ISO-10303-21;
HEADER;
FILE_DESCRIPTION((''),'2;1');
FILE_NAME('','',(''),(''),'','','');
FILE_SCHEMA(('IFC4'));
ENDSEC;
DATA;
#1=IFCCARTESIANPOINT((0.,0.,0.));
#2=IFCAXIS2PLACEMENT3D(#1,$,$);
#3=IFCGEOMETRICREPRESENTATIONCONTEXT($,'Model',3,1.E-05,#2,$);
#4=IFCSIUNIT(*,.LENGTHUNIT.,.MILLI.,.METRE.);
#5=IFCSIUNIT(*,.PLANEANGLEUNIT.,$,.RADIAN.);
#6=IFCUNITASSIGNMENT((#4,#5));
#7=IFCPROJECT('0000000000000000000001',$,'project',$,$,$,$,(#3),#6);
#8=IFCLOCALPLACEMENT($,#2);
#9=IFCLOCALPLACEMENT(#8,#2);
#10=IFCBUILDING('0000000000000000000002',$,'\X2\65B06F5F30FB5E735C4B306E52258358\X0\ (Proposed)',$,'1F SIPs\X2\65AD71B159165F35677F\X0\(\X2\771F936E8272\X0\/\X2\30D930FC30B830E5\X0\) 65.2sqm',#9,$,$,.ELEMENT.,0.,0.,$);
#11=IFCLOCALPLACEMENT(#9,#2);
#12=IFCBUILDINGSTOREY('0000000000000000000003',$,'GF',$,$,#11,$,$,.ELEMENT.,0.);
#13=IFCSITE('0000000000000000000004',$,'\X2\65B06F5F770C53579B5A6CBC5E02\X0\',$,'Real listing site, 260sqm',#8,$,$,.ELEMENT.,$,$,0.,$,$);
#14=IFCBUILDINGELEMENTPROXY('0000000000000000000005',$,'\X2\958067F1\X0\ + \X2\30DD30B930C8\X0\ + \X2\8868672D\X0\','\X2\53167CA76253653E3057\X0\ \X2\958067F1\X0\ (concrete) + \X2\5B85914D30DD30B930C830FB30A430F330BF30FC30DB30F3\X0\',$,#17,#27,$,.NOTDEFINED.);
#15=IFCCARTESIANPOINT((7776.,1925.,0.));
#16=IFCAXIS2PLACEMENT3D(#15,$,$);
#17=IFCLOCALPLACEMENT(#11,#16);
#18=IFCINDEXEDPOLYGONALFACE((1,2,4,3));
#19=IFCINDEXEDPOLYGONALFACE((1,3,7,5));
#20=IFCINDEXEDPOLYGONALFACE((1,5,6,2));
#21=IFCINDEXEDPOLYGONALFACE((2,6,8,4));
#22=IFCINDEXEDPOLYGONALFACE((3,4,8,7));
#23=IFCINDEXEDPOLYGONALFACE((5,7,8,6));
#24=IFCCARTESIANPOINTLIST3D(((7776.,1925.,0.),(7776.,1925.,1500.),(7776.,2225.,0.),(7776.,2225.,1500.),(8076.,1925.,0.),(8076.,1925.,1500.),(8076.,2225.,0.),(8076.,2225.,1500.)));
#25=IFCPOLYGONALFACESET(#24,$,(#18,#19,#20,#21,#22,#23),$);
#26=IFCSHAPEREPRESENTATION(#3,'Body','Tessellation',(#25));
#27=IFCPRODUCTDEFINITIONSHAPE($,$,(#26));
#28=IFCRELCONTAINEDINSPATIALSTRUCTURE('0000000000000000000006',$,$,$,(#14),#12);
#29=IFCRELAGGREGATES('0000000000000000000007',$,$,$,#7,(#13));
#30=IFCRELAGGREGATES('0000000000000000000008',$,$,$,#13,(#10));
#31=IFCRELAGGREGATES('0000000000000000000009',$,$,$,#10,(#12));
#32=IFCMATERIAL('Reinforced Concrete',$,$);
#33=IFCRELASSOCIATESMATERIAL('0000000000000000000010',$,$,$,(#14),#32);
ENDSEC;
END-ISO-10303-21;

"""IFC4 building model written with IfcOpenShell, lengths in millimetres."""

from ifc_helpers import new_model, si_unit, frame, frame_2d, origin, place, context, project, spatial, rectangle, extrude, material, element, save


model = new_model("IFC4")

# Units and contexts
model_context = context("Model", 3, precision=1e-05, world=origin())
ifc_project = project(units=[si_unit("LENGTHUNIT", "METRE", prefix="MILLI"), si_unit("PLANEANGLEUNIT", "RADIAN")], contexts=[model_context])

# Site, building, storey
site_placement = place(None, origin())
site = spatial("IfcSite", under=ifc_project, at=site_placement, Name="新潟県南魚沼市", ObjectType="Real listing site, 260sqm", CompositionType="ELEMENT", RefElevation=0.0)
building_placement = place(site_placement, origin())
building = spatial("IfcBuilding", under=site, at=building_placement, Name="新潟・平屋の別荘 (Proposed)", ObjectType="1F SIPs断熱外張板(真鍮色/ベージュ) 65.2sqm", CompositionType="ELEMENT", ElevationOfRefHeight=0.0, ElevationOfTerrain=0.0)
storey_placement = place(building_placement, origin())
storey = spatial("IfcBuildingStorey", under=building, at=storey_placement, Name="GF", CompositionType="ELEMENT", Elevation=0.0)

# Shared definitions
ifc_material_1 = material(Name="Reinforced Concrete")

# Building element proxy
proxy_placement = place(storey_placement, frame((7776.0, 1925.0, 0.0)))
element("IfcBuildingElementProxy", 1, at=proxy_placement, inside=storey, material=ifc_material_1, Name="門柱 + ポスト + 表札", Description="化粧打放し 門柱 (concrete) + 宅配ポスト・インターホン", PredefinedType="NOTDEFINED", context=model_context, shape_type="SweptSolid", body=[
    extrude(rectangle(XDim=300.0, YDim=300.0, at=frame_2d((150.0, 150.0))), frame((7776.0, 1925.0, 0.0)), (0.0, 0.0, 1.0), 1500.0),
])

save(model, "model.ifc")
